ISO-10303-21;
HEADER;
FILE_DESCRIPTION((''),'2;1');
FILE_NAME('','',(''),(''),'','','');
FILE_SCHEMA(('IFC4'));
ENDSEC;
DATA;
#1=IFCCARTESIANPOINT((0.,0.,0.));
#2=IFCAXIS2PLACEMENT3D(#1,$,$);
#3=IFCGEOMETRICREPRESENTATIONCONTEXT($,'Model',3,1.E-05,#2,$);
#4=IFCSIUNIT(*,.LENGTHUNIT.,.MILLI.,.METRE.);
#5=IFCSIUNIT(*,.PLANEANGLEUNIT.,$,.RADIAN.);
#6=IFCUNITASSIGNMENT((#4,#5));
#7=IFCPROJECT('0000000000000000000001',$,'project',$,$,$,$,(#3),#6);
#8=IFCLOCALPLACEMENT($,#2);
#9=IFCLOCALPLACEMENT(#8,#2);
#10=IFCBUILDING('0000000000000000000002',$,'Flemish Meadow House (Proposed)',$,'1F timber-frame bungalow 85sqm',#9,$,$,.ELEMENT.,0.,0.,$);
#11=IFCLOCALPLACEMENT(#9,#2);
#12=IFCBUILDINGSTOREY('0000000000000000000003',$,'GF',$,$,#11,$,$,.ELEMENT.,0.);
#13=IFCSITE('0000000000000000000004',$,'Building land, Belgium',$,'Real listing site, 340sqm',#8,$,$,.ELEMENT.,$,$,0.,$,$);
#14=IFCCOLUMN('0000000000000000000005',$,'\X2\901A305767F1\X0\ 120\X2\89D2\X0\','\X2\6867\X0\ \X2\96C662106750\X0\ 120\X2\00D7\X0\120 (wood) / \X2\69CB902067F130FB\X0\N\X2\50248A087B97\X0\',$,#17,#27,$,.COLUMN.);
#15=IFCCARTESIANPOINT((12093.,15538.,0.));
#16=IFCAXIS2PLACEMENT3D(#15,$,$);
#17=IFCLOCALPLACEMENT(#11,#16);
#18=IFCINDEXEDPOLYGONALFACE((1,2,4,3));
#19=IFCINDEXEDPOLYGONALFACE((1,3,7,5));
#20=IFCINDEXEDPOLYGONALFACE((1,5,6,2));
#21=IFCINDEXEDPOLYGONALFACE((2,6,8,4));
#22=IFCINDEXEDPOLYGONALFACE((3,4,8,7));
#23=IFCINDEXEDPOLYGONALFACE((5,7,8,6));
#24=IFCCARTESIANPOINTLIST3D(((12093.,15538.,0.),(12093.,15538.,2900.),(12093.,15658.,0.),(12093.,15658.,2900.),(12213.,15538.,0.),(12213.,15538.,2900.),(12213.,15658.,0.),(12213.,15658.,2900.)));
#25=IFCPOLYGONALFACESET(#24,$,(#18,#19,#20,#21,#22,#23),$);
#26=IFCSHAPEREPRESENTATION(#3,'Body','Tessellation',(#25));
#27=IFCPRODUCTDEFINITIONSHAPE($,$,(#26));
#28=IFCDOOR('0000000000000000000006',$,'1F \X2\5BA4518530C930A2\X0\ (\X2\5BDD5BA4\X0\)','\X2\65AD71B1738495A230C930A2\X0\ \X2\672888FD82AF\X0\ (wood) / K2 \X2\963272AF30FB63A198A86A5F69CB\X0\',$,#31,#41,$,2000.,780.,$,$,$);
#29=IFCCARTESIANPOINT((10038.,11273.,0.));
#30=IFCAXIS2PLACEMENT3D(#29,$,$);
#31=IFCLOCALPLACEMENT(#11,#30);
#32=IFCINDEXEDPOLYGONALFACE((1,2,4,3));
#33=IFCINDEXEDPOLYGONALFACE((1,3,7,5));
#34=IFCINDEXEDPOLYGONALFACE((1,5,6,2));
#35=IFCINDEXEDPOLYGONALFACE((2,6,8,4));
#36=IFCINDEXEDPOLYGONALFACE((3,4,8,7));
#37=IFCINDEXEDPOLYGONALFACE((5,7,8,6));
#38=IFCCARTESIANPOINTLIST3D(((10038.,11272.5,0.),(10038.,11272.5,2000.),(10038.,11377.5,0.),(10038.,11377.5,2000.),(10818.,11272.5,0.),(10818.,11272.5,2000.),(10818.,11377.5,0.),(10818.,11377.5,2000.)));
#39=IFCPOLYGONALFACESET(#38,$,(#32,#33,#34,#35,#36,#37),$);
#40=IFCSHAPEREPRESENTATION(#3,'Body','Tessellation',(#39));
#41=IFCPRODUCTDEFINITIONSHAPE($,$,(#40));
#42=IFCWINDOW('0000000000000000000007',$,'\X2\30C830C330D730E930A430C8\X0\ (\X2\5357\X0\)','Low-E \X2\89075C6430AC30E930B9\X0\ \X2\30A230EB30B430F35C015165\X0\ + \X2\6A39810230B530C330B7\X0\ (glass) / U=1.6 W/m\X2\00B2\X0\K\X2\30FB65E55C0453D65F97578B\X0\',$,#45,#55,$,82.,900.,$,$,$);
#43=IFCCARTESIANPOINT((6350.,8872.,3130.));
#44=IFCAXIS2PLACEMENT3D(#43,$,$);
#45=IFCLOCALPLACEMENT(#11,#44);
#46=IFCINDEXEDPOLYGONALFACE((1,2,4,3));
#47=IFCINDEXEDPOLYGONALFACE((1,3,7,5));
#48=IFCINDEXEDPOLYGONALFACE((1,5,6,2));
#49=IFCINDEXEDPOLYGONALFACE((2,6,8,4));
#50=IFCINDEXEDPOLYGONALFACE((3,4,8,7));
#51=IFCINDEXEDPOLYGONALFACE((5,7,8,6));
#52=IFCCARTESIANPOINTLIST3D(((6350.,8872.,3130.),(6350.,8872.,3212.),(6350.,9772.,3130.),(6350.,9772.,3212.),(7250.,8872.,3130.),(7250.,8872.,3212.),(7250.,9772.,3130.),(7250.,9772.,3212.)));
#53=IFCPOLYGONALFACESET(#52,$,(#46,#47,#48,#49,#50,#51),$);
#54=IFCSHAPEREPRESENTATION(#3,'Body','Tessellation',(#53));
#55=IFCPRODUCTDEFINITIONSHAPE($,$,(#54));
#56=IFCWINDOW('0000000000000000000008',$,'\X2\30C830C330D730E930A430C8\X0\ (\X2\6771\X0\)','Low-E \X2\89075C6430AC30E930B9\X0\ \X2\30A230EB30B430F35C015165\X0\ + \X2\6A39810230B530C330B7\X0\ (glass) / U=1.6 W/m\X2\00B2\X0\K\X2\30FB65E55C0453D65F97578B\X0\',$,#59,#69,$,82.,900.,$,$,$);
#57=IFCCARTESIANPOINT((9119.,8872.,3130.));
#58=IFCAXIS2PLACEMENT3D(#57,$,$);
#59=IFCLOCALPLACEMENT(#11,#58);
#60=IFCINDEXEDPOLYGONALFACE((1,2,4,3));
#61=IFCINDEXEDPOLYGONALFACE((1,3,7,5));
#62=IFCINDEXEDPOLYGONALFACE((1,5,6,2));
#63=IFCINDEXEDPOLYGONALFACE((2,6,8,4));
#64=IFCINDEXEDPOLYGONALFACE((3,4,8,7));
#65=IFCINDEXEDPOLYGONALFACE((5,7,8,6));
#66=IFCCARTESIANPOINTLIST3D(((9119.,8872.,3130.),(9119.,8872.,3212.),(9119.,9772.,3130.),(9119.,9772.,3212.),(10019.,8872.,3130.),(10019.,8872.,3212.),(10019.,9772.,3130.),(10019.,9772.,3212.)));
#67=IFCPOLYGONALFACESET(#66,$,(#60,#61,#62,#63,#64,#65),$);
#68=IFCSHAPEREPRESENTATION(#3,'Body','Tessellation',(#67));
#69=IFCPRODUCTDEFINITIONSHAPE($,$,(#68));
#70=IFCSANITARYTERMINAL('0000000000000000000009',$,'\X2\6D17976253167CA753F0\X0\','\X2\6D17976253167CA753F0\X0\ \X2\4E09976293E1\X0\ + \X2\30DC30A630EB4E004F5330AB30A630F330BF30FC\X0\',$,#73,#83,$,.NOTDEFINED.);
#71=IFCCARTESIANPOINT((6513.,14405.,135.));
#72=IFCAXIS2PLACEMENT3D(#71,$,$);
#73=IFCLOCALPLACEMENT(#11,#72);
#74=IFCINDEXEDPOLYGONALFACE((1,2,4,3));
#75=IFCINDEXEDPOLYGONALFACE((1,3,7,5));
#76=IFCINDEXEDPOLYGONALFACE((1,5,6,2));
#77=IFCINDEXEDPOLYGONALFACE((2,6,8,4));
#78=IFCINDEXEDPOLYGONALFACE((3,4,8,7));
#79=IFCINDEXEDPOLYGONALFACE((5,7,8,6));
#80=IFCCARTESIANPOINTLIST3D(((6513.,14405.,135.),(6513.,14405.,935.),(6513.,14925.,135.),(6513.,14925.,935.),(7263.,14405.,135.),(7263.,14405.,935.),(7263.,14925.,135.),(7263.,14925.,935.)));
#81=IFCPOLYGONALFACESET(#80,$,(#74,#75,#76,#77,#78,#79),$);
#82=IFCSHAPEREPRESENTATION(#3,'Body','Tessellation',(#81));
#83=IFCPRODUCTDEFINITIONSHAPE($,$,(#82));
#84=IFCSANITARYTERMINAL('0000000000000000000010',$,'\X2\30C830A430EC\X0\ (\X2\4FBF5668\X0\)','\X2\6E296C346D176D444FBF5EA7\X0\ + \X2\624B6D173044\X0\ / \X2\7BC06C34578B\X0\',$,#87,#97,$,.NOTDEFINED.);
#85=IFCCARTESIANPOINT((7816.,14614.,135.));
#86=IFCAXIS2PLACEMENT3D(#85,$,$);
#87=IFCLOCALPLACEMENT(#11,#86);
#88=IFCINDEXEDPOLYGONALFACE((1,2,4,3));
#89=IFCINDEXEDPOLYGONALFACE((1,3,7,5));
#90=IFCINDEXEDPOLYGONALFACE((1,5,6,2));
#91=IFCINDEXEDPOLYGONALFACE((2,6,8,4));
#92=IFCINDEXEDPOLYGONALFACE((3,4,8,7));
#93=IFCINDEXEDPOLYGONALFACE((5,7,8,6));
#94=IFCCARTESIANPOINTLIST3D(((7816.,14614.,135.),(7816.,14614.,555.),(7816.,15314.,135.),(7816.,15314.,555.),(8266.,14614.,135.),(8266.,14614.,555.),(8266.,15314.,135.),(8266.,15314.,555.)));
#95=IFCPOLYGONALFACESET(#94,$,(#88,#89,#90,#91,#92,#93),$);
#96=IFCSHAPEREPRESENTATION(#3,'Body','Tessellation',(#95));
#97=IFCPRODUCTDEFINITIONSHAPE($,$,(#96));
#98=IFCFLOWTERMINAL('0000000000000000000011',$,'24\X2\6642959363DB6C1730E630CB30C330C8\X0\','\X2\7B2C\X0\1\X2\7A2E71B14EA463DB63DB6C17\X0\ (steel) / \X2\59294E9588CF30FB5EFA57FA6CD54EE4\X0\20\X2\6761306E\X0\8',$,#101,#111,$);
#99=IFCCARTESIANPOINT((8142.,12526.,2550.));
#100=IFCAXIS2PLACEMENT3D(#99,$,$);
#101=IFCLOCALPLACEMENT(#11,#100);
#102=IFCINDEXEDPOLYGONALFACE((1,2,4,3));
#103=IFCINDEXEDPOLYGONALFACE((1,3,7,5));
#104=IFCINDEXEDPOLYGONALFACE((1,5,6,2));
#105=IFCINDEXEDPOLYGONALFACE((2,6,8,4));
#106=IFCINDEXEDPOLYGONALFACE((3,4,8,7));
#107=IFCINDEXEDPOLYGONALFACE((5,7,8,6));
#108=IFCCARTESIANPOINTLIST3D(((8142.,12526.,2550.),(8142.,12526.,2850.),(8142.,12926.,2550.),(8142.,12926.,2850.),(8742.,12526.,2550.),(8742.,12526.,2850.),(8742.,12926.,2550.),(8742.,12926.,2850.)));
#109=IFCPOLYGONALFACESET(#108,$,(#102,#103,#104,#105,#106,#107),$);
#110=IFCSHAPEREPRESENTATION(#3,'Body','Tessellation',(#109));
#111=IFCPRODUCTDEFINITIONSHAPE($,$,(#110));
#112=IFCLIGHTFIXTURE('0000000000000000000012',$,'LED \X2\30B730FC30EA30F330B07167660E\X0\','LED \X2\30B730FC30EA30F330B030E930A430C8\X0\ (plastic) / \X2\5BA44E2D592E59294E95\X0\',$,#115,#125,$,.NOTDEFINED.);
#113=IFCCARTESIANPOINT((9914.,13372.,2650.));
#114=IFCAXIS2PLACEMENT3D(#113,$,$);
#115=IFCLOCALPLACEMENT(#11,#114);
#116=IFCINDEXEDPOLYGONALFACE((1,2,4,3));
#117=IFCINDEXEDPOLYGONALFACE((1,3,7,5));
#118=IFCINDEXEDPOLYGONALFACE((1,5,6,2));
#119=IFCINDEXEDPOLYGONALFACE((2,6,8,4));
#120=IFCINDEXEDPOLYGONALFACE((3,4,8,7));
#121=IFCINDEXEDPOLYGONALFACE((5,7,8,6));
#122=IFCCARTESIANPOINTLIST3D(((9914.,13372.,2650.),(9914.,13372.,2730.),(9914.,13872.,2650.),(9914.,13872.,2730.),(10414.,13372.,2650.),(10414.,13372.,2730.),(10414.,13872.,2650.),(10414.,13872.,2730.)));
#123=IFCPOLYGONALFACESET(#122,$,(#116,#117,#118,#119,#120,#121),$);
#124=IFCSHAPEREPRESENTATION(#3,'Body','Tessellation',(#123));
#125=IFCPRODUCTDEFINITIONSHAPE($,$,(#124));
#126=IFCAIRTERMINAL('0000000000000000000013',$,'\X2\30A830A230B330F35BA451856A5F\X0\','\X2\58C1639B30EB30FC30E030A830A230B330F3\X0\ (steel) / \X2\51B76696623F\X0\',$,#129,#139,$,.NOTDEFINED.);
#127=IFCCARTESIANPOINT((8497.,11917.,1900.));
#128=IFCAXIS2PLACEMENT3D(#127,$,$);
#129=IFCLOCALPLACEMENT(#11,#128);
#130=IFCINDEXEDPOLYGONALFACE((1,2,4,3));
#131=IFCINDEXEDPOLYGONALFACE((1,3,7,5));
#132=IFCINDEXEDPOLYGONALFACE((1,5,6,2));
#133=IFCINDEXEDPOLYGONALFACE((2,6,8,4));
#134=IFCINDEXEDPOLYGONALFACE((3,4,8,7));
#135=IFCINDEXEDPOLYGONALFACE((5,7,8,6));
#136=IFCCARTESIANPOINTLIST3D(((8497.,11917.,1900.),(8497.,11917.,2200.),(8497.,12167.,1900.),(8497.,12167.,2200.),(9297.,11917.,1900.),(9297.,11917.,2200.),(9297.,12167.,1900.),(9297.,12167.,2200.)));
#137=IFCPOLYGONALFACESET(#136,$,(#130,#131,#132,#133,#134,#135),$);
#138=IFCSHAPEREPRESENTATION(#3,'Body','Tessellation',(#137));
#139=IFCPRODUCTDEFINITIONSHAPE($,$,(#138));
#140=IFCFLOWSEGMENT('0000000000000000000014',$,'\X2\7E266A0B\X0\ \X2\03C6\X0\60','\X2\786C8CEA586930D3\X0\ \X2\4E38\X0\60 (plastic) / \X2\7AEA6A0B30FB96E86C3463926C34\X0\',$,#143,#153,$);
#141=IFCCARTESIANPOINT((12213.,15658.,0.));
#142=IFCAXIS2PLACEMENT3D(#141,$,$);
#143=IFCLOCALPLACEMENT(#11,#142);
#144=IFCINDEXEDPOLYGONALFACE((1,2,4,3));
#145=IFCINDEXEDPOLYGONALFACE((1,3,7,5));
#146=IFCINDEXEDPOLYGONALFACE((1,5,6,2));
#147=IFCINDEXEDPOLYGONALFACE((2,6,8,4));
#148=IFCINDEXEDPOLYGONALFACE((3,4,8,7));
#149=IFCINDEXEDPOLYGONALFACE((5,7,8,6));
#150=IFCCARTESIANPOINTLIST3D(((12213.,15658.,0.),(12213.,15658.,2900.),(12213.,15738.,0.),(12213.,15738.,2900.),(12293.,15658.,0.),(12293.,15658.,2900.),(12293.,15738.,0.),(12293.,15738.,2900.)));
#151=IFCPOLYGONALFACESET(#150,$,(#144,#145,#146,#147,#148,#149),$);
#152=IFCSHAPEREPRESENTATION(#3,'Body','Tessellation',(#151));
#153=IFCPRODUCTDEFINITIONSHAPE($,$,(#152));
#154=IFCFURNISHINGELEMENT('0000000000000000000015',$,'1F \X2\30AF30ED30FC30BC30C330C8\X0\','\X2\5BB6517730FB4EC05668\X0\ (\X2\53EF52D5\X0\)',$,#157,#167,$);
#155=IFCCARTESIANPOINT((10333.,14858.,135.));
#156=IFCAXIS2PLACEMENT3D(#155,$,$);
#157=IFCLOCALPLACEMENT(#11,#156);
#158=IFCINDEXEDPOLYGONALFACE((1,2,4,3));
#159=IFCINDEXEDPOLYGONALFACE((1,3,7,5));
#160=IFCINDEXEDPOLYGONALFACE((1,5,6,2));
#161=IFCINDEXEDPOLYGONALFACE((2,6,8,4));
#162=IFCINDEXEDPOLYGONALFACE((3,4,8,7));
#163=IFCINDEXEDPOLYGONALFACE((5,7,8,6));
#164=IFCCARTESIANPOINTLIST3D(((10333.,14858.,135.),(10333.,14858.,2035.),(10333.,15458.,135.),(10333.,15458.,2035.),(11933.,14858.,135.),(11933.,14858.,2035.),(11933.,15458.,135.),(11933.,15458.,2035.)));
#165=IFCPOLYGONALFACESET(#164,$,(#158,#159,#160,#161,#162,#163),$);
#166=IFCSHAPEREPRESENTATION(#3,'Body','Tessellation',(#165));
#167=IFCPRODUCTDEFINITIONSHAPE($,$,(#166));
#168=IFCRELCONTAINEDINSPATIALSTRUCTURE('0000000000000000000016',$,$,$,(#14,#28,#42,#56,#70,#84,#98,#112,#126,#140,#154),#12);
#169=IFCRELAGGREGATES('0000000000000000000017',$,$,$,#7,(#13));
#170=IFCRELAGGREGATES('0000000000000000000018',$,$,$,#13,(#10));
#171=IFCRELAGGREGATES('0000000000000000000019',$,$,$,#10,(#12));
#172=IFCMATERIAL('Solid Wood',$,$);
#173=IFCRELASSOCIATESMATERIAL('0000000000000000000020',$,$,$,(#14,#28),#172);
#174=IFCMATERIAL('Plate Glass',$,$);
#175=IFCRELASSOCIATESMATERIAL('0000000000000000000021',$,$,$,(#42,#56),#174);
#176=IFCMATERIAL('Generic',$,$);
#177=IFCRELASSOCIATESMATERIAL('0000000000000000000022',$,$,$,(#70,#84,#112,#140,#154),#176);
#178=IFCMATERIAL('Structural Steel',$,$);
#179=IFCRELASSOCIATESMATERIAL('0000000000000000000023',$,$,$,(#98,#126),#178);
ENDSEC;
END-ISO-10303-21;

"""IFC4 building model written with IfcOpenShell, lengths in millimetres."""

from ifc_helpers import new_model, si_unit, frame, frame_2d, origin, place, context, project, spatial, rectangle, extrude, material, element, save


model = new_model("IFC4")

# Units and contexts
model_context = context("Model", 3, precision=1e-05, world=origin())
ifc_project = project(units=[si_unit("LENGTHUNIT", "METRE", prefix="MILLI"), si_unit("PLANEANGLEUNIT", "RADIAN")], contexts=[model_context])

# Site, building, storey
site_placement = place(None, origin())
site = spatial("IfcSite", under=ifc_project, at=site_placement, Name="Building land, Belgium", ObjectType="Real listing site, 340sqm", CompositionType="ELEMENT", RefElevation=0.0)
building_placement = place(site_placement, origin())
building = spatial("IfcBuilding", under=site, at=building_placement, Name="Flemish Meadow House (Proposed)", ObjectType="1F timber-frame bungalow 85sqm", CompositionType="ELEMENT", ElevationOfRefHeight=0.0, ElevationOfTerrain=0.0)
storey_placement = place(building_placement, origin())
storey = spatial("IfcBuildingStorey", under=building, at=storey_placement, Name="GF", CompositionType="ELEMENT", Elevation=0.0)

# Column
ifc_material_1 = material(Name="Solid Wood")
column_1_placement = place(storey_placement, frame((12093.0, 15538.0, 0.0)))
element("IfcColumn", 1, at=column_1_placement, inside=storey, material=ifc_material_1, Name="通し柱 120角", Description="桧 集成材 120×120 (wood) / 構造柱・N値計算", PredefinedType="COLUMN", context=model_context, shape_type="SweptSolid", body=[
    extrude(rectangle(XDim=120.0, YDim=120.0, at=frame_2d((60.0, 60.0))), frame((12093.0, 15538.0, 0.0)), (0.0, 0.0, 1.0), 2900.0),
])

# Door
door_placement = place(storey_placement, frame((10038.0, 11273.0, 0.0)))
element("IfcDoor", 2, at=door_placement, inside=storey, material=ifc_material_1, Name="1F 室内ドア (寝室)", Description="断熱玄関ドア 木製芯 (wood) / K2 防犯・採風機構", OverallHeight=2000.0, OverallWidth=780.0, context=model_context, shape_type="SweptSolid", body=[
    extrude(rectangle(XDim=780.0, YDim=105.0, at=frame_2d((390.0, 52.0))), frame((10038.0, 11273.0, 0.0)), (0.0, 0.0, 1.0), 2000.0),
])

# Windows
ifc_material_2 = material(Name="Plate Glass")
window_1_placement = place(storey_placement, frame((6350.0, 8872.0, 3130.0)))
element("IfcWindow", 3, at=window_1_placement, inside=storey, material=ifc_material_2, Name="トップライト (南)", Description="Low-E 複層ガラス アルゴン封入 + 樹脂サッシ (glass) / U=1.6 W/m²K・日射取得型", OverallHeight=82.0, OverallWidth=900.0, context=model_context, shape_type="SweptSolid", body=[
    extrude(rectangle(XDim=900.0, YDim=900.0, at=frame_2d((450.0, 450.0))), frame((6350.0, 8872.0, 3130.0)), (0.0, 0.0, 1.0), 82.0),
])
window_2_placement = place(storey_placement, frame((9119.0, 8872.0, 3130.0)))
element("IfcWindow", 4, at=window_2_placement, inside=storey, material=ifc_material_2, Name="トップライト (東)", Description="Low-E 複層ガラス アルゴン封入 + 樹脂サッシ (glass) / U=1.6 W/m²K・日射取得型", OverallHeight=82.0, OverallWidth=900.0, context=model_context, shape_type="SweptSolid", body=[
    extrude(rectangle(XDim=900.0, YDim=900.0, at=frame_2d((450.0, 450.0))), frame((9119.0, 8872.0, 3130.0)), (0.0, 0.0, 1.0), 82.0),
])

# Sanitary terminals
ifc_material_3 = material(Name="Generic")
sanitary_terminal_1_placement = place(storey_placement, frame((6513.0, 14405.0, 135.0)))
element("IfcSanitaryTerminal", 5, at=sanitary_terminal_1_placement, inside=storey, material=ifc_material_3, Name="洗面化粧台", Description="洗面化粧台 三面鏡 + ボウル一体カウンター", PredefinedType="NOTDEFINED", context=model_context, shape_type="SweptSolid", body=[
    extrude(rectangle(XDim=750.0, YDim=520.0, at=frame_2d((375.0, 260.0))), frame((6513.0, 14405.0, 135.0)), (0.0, 0.0, 1.0), 800.0),
])
sanitary_terminal_2_placement = place(storey_placement, frame((7816.0, 14614.0, 135.0)))
element("IfcSanitaryTerminal", 6, at=sanitary_terminal_2_placement, inside=storey, material=ifc_material_3, Name="トイレ (便器)", Description="温水洗浄便座 + 手洗い / 節水型", PredefinedType="NOTDEFINED", context=model_context, shape_type="SweptSolid", body=[
    extrude(rectangle(XDim=450.0, YDim=700.0, at=frame_2d((225.0, 350.0))), frame((7816.0, 14614.0, 135.0)), (0.0, 0.0, 1.0), 420.0),
])

# Flow terminal
ifc_material_4 = material(Name="Structural Steel")
flow_terminal_placement = place(storey_placement, frame((8142.0, 12526.0, 2550.0)))
element("IfcFlowTerminal", 7, at=flow_terminal_placement, inside=storey, material=ifc_material_4, Name="24時間換気ユニット", Description="第1種熱交換換気 (steel) / 天井裏・建基法令20条の8", context=model_context, shape_type="SweptSolid", body=[
    extrude(rectangle(XDim=600.0, YDim=400.0, at=frame_2d((300.0, 200.0))), frame((8142.0, 12526.0, 2550.0)), (0.0, 0.0, 1.0), 300.0),
])

# Light fixture
light_fixture_placement = place(storey_placement, frame((9914.0, 13372.0, 2650.0)))
element("IfcLightFixture", 8, at=light_fixture_placement, inside=storey, material=ifc_material_3, Name="LED シーリング照明", Description="LED シーリングライト (plastic) / 室中央天井", PredefinedType="NOTDEFINED", context=model_context, shape_type="SweptSolid", body=[
    extrude(rectangle(XDim=500.0, YDim=500.0, at=frame_2d((250.0, 250.0))), frame((9914.0, 13372.0, 2650.0)), (0.0, 0.0, 1.0), 80.0),
])

# Air terminal
air_terminal_placement = place(storey_placement, frame((8497.0, 11917.0, 1900.0)))
element("IfcAirTerminal", 9, at=air_terminal_placement, inside=storey, material=ifc_material_4, Name="エアコン室内機", Description="壁掛ルームエアコン (steel) / 冷暖房", PredefinedType="NOTDEFINED", context=model_context, shape_type="SweptSolid", body=[
    extrude(rectangle(XDim=800.0, YDim=250.0, at=frame_2d((400.0, 125.0))), frame((8497.0, 11917.0, 1900.0)), (0.0, 0.0, 1.0), 300.0),
])

# Flow segment
flow_segment_placement = place(storey_placement, frame((12213.0, 15658.0, 0.0)))
element("IfcFlowSegment", 10, at=flow_segment_placement, inside=storey, material=ifc_material_3, Name="縦樋 φ60", Description="硬質塩ビ 丸60 (plastic) / 竪樋・雨水排水", context=model_context, shape_type="SweptSolid", body=[
    extrude(rectangle(XDim=80.0, YDim=80.0, at=frame_2d((40.0, 40.0))), frame((12213.0, 15658.0, 0.0)), (0.0, 0.0, 1.0), 2900.0),
])

# Furnishing element
furnishing_placement = place(storey_placement, frame((10333.0, 14858.0, 135.0)))
element("IfcFurnishingElement", 11, at=furnishing_placement, inside=storey, material=ifc_material_3, Name="1F クローゼット", Description="家具・什器 (可動)", context=model_context, shape_type="SweptSolid", body=[
    extrude(rectangle(XDim=1600.0, YDim=600.0, at=frame_2d((800.0, 300.0))), frame((10333.0, 14858.0, 135.0)), (0.0, 0.0, 1.0), 1900.0),
])

save(model, "model.ifc")
